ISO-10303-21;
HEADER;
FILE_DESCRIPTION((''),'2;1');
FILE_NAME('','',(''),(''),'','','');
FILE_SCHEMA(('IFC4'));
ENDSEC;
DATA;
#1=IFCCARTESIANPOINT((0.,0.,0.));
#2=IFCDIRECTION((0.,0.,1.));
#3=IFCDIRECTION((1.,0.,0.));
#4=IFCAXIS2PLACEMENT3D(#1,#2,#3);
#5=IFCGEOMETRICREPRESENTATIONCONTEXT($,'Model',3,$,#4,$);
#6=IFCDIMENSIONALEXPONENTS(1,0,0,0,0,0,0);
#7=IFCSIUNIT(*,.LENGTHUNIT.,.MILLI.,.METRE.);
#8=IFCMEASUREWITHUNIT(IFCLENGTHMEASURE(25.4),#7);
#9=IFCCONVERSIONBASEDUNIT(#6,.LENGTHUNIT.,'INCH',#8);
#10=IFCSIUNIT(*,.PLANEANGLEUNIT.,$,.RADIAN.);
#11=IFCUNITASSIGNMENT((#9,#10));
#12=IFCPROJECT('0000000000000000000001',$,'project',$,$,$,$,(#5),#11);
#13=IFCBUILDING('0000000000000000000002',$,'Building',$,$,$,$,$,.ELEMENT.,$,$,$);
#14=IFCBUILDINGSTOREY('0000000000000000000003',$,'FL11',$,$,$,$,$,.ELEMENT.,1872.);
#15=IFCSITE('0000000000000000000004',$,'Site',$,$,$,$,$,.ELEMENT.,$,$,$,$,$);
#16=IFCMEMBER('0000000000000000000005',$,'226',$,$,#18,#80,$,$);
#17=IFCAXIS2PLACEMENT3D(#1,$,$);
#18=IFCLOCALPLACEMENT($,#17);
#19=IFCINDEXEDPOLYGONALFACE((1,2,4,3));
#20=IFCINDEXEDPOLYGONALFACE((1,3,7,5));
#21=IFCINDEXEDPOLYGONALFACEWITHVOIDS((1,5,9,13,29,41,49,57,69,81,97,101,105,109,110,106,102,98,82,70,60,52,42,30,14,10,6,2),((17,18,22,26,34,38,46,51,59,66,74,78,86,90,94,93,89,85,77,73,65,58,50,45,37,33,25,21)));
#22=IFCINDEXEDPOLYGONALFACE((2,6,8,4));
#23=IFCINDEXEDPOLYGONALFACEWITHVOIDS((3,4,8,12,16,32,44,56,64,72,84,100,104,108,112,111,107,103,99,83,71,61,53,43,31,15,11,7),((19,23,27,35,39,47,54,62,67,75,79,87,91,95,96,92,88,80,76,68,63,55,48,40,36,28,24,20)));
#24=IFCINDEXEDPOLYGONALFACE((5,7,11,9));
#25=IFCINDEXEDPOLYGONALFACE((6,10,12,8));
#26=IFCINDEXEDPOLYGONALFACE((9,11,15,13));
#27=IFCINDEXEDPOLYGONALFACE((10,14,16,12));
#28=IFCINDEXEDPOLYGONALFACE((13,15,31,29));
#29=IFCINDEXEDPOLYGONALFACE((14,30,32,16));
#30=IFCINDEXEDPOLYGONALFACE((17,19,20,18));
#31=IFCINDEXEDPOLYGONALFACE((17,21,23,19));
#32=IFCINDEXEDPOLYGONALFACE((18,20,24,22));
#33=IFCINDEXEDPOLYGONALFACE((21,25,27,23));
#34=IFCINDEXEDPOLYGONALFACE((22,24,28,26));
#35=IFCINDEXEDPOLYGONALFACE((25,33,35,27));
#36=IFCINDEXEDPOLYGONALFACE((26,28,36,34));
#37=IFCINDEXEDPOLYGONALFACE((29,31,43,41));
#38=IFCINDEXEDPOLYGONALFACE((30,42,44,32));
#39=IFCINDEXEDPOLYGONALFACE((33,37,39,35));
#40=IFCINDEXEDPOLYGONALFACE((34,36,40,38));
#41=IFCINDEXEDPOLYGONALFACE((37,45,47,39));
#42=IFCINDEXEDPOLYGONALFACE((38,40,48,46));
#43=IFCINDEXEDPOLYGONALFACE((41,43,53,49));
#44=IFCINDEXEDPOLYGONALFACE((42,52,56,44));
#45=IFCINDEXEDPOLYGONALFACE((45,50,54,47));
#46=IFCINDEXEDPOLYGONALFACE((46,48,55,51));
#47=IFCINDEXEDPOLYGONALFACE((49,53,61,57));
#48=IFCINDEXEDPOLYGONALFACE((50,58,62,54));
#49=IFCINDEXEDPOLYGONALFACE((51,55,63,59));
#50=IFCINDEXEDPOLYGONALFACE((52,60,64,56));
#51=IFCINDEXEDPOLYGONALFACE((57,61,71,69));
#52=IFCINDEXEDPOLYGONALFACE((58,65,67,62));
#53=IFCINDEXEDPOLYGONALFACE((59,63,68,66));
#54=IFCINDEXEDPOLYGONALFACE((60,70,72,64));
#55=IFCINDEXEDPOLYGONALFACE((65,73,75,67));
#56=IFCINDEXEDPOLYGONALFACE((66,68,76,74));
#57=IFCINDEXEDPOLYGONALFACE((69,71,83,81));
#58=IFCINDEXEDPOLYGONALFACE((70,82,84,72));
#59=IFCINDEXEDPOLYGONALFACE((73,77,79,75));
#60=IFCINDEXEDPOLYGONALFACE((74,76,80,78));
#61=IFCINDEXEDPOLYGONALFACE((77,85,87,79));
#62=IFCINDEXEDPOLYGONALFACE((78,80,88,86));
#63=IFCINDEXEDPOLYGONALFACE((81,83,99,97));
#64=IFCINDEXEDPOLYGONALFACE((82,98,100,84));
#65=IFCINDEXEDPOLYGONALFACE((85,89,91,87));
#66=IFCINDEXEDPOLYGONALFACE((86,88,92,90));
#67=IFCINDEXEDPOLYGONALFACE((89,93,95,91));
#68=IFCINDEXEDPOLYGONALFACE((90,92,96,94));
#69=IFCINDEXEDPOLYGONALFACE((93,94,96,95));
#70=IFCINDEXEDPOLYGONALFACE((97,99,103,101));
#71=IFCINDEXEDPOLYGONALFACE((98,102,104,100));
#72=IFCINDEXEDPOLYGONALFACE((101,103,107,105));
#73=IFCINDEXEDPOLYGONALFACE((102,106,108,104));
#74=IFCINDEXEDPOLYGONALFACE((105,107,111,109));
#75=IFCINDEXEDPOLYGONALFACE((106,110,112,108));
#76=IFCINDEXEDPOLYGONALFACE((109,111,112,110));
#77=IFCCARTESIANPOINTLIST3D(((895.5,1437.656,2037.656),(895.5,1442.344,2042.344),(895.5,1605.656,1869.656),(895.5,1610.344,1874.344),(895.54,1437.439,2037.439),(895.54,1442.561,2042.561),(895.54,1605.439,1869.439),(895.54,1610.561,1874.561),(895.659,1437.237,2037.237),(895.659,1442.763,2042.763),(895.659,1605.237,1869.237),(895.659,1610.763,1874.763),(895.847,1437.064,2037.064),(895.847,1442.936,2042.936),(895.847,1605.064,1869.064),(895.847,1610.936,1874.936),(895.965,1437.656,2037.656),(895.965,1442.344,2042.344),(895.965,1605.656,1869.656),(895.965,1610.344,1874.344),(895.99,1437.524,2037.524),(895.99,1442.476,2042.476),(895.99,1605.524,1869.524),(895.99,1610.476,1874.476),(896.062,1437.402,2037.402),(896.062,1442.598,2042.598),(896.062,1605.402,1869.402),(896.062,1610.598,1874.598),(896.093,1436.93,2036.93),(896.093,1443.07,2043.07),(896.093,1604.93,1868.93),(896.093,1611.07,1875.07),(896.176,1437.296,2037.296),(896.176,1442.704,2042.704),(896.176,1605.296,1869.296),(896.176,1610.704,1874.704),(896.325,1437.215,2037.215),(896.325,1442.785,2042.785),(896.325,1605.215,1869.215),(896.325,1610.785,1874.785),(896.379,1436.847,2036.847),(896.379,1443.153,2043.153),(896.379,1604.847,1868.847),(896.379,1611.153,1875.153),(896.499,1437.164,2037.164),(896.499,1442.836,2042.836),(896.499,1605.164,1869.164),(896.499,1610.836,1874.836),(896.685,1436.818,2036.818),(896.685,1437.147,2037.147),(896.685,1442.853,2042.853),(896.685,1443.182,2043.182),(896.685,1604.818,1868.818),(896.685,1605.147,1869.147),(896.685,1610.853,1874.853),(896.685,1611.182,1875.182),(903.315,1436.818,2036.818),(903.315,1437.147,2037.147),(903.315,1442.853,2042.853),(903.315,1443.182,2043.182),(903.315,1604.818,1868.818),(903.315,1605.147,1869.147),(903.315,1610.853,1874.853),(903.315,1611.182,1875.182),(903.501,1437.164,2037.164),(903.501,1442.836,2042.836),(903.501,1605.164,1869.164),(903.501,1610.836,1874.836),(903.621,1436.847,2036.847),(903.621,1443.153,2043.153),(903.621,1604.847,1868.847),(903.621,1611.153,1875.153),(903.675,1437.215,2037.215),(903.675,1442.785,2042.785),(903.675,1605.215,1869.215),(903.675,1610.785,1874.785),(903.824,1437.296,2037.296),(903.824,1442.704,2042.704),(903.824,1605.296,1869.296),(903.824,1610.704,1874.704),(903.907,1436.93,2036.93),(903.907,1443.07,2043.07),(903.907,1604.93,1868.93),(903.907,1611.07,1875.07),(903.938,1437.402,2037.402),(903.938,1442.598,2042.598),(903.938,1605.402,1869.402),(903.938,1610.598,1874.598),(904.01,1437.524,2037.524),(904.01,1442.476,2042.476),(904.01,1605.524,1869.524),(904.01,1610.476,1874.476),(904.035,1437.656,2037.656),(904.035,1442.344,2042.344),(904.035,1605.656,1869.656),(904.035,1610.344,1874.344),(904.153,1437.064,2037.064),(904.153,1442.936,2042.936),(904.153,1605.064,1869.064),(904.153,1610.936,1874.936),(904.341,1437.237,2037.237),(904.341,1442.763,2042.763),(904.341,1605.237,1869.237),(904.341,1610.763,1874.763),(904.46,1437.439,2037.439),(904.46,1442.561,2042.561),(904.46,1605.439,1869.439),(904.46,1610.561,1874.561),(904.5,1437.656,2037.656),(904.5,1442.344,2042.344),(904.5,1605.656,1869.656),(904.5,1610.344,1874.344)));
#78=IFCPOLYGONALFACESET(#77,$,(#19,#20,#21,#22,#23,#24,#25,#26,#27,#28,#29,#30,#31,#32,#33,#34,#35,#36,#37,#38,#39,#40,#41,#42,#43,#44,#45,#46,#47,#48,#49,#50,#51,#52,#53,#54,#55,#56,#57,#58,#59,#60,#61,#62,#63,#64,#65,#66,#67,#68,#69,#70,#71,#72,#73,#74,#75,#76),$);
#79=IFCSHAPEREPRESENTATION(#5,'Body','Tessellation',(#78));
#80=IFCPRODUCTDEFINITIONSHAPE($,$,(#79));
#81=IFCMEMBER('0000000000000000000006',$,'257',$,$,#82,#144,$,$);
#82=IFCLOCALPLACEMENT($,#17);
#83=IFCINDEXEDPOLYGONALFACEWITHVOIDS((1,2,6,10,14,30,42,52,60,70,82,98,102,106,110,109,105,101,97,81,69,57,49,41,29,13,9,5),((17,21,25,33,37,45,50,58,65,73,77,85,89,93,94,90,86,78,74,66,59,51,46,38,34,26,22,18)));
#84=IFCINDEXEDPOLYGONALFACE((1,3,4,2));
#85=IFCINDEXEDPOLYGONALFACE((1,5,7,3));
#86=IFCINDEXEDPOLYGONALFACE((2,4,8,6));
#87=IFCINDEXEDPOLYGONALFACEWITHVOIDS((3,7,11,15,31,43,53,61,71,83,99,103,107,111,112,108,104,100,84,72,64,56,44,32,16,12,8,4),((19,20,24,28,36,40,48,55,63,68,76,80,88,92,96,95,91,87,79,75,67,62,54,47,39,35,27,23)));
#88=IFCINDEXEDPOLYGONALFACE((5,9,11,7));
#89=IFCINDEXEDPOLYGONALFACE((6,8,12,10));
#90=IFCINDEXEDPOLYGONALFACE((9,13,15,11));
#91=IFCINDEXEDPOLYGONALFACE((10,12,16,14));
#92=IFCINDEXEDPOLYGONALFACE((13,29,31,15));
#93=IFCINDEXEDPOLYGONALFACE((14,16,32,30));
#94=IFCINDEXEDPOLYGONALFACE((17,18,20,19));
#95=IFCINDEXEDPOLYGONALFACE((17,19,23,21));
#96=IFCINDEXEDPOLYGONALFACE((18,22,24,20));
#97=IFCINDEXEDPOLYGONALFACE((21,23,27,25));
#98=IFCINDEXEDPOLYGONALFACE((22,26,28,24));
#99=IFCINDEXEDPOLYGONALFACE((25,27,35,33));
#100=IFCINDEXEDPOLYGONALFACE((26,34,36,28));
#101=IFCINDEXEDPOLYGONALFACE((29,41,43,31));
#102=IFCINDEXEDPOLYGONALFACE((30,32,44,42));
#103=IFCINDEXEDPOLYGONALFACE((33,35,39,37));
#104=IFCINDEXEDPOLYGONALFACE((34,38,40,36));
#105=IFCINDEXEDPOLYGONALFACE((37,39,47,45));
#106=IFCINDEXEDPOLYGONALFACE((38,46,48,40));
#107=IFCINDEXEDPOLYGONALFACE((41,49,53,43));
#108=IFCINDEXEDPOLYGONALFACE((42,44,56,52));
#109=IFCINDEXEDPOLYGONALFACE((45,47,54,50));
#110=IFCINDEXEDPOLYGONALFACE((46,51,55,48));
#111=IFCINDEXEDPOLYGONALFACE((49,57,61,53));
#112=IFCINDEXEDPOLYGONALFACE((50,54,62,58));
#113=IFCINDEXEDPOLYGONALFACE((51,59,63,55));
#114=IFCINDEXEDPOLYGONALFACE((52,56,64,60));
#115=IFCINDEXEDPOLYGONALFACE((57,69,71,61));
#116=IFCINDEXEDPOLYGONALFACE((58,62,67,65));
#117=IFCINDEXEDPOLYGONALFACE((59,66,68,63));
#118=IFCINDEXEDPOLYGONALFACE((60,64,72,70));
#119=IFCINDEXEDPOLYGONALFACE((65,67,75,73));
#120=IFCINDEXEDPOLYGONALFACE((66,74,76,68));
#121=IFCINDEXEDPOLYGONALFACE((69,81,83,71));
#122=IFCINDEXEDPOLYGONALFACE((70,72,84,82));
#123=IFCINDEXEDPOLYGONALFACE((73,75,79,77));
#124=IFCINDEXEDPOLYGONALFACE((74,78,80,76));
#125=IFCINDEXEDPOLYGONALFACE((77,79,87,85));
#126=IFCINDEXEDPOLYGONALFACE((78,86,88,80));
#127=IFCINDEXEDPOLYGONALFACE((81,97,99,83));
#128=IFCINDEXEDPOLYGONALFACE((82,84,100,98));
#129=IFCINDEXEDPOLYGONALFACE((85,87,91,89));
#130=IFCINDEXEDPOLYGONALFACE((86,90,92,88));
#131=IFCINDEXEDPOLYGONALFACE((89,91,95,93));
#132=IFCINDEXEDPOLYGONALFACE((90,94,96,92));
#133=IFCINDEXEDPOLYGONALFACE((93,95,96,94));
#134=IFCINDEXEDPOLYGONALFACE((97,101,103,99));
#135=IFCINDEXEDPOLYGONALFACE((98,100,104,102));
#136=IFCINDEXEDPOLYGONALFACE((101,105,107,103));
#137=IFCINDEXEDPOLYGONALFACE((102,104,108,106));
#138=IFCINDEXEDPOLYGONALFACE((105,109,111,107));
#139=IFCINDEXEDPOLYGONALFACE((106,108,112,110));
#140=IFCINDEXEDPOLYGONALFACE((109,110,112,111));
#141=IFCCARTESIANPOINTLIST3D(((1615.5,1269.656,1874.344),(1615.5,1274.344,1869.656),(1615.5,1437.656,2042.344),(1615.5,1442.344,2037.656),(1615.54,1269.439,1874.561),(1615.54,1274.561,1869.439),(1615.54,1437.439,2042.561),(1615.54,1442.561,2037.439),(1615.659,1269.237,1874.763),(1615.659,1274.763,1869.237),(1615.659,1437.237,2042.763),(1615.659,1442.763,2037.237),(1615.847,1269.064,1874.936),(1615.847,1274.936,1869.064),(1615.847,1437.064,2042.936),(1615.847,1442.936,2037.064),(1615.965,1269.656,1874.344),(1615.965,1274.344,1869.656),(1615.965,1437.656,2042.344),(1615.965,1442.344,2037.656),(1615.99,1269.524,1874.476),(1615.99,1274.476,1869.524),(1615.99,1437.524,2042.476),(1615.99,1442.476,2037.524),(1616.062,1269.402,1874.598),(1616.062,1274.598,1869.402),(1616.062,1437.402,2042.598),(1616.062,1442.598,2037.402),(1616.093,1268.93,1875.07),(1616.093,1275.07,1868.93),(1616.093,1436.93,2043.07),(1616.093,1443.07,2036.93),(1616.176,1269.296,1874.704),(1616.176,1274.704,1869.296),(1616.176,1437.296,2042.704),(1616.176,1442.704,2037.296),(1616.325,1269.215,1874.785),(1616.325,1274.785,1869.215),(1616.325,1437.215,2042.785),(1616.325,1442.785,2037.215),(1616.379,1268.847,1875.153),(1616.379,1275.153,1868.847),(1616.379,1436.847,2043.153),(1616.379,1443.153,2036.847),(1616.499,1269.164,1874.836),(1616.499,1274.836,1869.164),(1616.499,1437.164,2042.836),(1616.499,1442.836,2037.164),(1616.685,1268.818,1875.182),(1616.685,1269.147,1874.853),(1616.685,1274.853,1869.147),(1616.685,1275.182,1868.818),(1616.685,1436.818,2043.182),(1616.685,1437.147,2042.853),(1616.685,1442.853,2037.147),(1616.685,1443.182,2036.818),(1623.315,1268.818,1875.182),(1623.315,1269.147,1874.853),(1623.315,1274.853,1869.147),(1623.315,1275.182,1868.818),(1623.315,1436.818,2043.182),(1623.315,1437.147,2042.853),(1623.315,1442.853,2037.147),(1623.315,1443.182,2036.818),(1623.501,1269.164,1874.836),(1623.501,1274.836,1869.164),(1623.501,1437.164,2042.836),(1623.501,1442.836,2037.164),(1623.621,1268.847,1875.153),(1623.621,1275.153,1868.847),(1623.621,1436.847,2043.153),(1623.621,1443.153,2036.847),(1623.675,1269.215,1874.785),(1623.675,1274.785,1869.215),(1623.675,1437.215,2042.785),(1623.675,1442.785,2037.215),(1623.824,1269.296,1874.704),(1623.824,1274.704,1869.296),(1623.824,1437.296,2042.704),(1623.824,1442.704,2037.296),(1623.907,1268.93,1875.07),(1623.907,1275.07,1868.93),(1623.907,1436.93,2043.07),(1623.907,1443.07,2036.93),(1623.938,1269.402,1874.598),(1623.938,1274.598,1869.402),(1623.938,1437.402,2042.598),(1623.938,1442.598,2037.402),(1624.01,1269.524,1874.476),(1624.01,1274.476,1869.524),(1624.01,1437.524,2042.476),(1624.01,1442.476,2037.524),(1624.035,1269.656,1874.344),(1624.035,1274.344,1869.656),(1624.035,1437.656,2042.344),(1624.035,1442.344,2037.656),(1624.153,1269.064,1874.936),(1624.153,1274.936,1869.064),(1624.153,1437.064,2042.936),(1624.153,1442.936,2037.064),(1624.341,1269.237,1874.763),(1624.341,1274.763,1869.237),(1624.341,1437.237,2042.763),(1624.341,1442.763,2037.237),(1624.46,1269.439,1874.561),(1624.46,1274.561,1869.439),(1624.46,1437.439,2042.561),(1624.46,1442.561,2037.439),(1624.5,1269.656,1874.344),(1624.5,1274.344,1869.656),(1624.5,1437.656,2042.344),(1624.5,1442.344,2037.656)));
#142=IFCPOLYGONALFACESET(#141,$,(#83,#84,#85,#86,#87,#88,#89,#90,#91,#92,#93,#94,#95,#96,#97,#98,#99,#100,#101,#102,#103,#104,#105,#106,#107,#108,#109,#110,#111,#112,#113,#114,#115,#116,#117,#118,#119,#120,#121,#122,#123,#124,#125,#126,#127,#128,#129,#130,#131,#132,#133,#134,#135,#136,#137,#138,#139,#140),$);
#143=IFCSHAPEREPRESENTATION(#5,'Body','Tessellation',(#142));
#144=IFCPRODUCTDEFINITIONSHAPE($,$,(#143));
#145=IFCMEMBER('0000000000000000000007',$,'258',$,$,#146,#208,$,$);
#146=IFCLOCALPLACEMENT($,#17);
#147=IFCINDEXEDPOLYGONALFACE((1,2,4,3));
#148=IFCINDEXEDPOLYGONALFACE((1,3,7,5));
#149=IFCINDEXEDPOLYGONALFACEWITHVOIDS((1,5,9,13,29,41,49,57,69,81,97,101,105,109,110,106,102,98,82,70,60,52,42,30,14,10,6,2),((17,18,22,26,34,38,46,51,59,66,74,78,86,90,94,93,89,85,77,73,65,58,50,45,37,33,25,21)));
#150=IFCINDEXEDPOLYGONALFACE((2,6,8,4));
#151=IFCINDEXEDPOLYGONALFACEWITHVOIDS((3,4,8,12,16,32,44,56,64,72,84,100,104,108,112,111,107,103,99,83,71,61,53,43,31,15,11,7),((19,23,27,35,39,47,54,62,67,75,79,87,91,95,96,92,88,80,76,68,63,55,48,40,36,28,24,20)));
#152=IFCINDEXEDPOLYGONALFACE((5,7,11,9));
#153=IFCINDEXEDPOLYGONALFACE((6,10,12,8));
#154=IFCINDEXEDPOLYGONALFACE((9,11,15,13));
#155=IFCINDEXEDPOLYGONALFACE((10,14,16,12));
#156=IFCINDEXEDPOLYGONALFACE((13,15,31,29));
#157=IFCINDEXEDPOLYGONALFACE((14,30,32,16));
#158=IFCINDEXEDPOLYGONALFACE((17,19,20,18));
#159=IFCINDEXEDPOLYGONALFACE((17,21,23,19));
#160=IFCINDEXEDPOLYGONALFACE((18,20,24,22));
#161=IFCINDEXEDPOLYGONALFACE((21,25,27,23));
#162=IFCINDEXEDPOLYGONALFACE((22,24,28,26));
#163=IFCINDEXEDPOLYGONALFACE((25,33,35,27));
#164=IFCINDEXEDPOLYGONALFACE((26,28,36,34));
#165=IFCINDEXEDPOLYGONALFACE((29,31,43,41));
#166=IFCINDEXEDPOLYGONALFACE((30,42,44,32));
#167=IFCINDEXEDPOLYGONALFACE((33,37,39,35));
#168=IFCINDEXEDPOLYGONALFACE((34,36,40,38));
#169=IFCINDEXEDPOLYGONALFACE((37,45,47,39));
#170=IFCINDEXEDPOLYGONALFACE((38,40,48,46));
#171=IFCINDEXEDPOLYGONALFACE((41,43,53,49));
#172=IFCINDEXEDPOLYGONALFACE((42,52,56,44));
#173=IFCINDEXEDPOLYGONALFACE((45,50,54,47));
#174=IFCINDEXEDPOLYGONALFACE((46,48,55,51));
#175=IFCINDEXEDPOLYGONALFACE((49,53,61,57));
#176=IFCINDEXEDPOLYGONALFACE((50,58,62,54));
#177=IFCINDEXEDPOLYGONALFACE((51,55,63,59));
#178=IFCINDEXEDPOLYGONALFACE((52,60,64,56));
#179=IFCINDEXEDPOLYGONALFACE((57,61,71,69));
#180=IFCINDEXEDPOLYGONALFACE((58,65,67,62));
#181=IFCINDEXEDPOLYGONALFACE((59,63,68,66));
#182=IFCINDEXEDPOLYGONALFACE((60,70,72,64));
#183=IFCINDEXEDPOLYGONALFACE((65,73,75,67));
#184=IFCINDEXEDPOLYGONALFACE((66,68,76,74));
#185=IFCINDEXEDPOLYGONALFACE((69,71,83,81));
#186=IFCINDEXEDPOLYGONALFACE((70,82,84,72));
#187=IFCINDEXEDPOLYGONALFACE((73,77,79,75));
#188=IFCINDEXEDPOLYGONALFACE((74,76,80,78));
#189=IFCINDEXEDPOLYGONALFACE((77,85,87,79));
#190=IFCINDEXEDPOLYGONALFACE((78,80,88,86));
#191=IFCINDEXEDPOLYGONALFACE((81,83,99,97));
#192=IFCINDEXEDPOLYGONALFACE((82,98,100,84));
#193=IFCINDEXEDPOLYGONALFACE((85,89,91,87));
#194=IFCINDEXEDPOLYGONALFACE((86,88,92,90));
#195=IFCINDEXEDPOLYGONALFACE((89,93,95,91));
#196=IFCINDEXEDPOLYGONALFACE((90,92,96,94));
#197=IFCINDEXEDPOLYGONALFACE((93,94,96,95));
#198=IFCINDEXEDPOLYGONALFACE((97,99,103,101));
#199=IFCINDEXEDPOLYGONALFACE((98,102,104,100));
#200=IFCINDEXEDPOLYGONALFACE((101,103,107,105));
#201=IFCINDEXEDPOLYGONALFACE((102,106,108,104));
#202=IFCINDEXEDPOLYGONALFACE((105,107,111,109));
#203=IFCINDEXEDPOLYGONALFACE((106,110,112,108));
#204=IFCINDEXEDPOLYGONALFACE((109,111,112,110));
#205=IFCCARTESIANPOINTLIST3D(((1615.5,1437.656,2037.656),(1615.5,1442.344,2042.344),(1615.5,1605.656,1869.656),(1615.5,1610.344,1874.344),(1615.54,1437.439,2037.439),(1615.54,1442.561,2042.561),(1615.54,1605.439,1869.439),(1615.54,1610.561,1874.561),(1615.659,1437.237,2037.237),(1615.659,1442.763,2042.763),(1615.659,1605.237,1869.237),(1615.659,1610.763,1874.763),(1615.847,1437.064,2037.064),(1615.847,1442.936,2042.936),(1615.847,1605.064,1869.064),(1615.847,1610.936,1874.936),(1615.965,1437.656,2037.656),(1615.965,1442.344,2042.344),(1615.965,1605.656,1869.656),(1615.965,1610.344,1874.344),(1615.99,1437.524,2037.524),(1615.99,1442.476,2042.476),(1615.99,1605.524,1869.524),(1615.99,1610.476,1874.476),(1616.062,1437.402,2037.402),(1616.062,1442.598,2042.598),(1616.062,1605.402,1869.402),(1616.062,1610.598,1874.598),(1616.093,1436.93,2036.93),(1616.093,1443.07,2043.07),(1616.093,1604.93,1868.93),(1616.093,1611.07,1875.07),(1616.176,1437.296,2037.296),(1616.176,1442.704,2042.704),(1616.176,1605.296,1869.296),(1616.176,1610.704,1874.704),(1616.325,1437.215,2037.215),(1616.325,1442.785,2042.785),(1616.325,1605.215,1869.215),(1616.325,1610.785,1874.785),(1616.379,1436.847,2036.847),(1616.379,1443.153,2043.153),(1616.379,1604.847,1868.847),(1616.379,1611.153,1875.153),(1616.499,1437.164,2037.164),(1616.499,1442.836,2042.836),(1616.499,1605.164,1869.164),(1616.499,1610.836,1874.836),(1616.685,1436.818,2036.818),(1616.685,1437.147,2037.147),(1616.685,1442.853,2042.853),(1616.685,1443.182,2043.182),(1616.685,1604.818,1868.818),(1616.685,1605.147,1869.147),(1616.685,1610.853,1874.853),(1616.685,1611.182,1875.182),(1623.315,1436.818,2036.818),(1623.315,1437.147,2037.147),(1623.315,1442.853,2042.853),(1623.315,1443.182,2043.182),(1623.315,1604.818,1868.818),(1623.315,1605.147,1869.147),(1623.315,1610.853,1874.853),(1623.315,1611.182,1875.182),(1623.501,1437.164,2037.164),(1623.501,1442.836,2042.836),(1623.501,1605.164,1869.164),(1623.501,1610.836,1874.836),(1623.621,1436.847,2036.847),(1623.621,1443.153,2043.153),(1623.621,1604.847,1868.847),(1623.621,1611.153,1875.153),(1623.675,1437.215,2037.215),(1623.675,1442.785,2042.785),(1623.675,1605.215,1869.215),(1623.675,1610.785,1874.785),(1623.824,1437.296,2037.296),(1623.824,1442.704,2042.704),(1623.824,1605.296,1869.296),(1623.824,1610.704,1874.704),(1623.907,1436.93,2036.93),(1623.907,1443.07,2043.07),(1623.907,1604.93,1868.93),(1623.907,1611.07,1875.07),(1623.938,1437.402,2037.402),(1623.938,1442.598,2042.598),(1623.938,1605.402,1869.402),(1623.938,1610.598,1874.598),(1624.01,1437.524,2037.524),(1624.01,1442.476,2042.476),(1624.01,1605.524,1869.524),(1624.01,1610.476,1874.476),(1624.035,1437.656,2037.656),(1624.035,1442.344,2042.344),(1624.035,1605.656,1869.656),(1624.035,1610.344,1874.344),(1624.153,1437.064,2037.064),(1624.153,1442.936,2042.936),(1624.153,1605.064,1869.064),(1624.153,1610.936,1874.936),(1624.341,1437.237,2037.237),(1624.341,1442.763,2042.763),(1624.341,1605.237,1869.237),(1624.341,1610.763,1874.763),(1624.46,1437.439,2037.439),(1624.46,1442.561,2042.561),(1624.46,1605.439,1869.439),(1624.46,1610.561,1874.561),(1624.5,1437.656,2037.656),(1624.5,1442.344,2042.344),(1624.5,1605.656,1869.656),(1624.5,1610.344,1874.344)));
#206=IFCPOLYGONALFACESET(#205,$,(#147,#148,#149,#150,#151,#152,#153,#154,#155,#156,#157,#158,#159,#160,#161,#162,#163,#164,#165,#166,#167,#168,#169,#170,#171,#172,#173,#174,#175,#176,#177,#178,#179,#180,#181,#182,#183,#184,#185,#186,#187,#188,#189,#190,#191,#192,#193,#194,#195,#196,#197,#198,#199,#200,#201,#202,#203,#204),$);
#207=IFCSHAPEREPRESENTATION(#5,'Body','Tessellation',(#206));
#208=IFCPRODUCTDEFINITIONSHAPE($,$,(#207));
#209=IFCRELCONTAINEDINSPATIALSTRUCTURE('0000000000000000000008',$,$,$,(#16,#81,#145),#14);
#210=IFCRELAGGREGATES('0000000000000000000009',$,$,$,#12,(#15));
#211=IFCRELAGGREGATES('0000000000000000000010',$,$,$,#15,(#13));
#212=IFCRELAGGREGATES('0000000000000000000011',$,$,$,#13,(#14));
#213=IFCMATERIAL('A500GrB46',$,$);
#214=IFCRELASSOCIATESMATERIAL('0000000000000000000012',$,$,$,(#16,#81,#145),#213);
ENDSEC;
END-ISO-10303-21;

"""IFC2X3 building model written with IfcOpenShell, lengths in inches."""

from ifc_helpers import new_model, entity, si_unit, converted_unit, frame, origin_with_axes, origin_2d_with_axis, place, context, project, spatial, hollow_rectangle, extrude, material, element, save


model = new_model("IFC2X3")

# Units and contexts
model_context = context("Model", 3, world=origin_with_axes())
ifc_project = project(units=[converted_unit("LENGTHUNIT", "INCH", entity("IfcLengthMeasure", 25.4), si_unit("LENGTHUNIT", "METRE", prefix="MILLI"), dimensions=[1, 0, 0, 0, 0, 0, 0]), si_unit("PLANEANGLEUNIT", "RADIAN")], contexts=[model_context])

# Site, building, storey
site = spatial("IfcSite", under=ifc_project, Name="Site", CompositionType="ELEMENT")
building = spatial("IfcBuilding", under=site, Name="Building", CompositionType="ELEMENT")
storey = spatial("IfcBuildingStorey", under=building, Name="FL11", CompositionType="ELEMENT", Elevation=1872.0)

# Members
ifc_material_1 = material(Name="A500GrB46")
for number, where, z_axis, x_axis, name in (
    (1, (900.0, 1608.0, 1872.0), (0.0, -0.707107, 0.707107), (1.0, 0.0, 0.0), "226"),
    (2, (1620.0, 1272.0, 1872.0), (0.0, 0.707107, 0.707107), (-1.0, 0.0, 0.0), "257"),
    (3, (1620.0, 1608.0, 1872.0), (0.0, -0.707107, 0.707107), (1.0, 0.0, 0.0), "258"),
):
    element("IfcMember", number, at=place(None, frame(where, z_axis=z_axis, x_axis=x_axis)), inside=storey, material=ifc_material_1, Name=name, context=model_context, shape_type="SweptSolid", body=[
        extrude(hollow_rectangle(XDim=9.0, YDim=9.0, WallThickness=0.465, InnerFilletRadius=0.72, OuterFilletRadius=1.185, at=origin_2d_with_axis()), origin_with_axes(), (0.0, 0.0, 1.0), 237.588),
    ])

save(model, "model.ifc")
